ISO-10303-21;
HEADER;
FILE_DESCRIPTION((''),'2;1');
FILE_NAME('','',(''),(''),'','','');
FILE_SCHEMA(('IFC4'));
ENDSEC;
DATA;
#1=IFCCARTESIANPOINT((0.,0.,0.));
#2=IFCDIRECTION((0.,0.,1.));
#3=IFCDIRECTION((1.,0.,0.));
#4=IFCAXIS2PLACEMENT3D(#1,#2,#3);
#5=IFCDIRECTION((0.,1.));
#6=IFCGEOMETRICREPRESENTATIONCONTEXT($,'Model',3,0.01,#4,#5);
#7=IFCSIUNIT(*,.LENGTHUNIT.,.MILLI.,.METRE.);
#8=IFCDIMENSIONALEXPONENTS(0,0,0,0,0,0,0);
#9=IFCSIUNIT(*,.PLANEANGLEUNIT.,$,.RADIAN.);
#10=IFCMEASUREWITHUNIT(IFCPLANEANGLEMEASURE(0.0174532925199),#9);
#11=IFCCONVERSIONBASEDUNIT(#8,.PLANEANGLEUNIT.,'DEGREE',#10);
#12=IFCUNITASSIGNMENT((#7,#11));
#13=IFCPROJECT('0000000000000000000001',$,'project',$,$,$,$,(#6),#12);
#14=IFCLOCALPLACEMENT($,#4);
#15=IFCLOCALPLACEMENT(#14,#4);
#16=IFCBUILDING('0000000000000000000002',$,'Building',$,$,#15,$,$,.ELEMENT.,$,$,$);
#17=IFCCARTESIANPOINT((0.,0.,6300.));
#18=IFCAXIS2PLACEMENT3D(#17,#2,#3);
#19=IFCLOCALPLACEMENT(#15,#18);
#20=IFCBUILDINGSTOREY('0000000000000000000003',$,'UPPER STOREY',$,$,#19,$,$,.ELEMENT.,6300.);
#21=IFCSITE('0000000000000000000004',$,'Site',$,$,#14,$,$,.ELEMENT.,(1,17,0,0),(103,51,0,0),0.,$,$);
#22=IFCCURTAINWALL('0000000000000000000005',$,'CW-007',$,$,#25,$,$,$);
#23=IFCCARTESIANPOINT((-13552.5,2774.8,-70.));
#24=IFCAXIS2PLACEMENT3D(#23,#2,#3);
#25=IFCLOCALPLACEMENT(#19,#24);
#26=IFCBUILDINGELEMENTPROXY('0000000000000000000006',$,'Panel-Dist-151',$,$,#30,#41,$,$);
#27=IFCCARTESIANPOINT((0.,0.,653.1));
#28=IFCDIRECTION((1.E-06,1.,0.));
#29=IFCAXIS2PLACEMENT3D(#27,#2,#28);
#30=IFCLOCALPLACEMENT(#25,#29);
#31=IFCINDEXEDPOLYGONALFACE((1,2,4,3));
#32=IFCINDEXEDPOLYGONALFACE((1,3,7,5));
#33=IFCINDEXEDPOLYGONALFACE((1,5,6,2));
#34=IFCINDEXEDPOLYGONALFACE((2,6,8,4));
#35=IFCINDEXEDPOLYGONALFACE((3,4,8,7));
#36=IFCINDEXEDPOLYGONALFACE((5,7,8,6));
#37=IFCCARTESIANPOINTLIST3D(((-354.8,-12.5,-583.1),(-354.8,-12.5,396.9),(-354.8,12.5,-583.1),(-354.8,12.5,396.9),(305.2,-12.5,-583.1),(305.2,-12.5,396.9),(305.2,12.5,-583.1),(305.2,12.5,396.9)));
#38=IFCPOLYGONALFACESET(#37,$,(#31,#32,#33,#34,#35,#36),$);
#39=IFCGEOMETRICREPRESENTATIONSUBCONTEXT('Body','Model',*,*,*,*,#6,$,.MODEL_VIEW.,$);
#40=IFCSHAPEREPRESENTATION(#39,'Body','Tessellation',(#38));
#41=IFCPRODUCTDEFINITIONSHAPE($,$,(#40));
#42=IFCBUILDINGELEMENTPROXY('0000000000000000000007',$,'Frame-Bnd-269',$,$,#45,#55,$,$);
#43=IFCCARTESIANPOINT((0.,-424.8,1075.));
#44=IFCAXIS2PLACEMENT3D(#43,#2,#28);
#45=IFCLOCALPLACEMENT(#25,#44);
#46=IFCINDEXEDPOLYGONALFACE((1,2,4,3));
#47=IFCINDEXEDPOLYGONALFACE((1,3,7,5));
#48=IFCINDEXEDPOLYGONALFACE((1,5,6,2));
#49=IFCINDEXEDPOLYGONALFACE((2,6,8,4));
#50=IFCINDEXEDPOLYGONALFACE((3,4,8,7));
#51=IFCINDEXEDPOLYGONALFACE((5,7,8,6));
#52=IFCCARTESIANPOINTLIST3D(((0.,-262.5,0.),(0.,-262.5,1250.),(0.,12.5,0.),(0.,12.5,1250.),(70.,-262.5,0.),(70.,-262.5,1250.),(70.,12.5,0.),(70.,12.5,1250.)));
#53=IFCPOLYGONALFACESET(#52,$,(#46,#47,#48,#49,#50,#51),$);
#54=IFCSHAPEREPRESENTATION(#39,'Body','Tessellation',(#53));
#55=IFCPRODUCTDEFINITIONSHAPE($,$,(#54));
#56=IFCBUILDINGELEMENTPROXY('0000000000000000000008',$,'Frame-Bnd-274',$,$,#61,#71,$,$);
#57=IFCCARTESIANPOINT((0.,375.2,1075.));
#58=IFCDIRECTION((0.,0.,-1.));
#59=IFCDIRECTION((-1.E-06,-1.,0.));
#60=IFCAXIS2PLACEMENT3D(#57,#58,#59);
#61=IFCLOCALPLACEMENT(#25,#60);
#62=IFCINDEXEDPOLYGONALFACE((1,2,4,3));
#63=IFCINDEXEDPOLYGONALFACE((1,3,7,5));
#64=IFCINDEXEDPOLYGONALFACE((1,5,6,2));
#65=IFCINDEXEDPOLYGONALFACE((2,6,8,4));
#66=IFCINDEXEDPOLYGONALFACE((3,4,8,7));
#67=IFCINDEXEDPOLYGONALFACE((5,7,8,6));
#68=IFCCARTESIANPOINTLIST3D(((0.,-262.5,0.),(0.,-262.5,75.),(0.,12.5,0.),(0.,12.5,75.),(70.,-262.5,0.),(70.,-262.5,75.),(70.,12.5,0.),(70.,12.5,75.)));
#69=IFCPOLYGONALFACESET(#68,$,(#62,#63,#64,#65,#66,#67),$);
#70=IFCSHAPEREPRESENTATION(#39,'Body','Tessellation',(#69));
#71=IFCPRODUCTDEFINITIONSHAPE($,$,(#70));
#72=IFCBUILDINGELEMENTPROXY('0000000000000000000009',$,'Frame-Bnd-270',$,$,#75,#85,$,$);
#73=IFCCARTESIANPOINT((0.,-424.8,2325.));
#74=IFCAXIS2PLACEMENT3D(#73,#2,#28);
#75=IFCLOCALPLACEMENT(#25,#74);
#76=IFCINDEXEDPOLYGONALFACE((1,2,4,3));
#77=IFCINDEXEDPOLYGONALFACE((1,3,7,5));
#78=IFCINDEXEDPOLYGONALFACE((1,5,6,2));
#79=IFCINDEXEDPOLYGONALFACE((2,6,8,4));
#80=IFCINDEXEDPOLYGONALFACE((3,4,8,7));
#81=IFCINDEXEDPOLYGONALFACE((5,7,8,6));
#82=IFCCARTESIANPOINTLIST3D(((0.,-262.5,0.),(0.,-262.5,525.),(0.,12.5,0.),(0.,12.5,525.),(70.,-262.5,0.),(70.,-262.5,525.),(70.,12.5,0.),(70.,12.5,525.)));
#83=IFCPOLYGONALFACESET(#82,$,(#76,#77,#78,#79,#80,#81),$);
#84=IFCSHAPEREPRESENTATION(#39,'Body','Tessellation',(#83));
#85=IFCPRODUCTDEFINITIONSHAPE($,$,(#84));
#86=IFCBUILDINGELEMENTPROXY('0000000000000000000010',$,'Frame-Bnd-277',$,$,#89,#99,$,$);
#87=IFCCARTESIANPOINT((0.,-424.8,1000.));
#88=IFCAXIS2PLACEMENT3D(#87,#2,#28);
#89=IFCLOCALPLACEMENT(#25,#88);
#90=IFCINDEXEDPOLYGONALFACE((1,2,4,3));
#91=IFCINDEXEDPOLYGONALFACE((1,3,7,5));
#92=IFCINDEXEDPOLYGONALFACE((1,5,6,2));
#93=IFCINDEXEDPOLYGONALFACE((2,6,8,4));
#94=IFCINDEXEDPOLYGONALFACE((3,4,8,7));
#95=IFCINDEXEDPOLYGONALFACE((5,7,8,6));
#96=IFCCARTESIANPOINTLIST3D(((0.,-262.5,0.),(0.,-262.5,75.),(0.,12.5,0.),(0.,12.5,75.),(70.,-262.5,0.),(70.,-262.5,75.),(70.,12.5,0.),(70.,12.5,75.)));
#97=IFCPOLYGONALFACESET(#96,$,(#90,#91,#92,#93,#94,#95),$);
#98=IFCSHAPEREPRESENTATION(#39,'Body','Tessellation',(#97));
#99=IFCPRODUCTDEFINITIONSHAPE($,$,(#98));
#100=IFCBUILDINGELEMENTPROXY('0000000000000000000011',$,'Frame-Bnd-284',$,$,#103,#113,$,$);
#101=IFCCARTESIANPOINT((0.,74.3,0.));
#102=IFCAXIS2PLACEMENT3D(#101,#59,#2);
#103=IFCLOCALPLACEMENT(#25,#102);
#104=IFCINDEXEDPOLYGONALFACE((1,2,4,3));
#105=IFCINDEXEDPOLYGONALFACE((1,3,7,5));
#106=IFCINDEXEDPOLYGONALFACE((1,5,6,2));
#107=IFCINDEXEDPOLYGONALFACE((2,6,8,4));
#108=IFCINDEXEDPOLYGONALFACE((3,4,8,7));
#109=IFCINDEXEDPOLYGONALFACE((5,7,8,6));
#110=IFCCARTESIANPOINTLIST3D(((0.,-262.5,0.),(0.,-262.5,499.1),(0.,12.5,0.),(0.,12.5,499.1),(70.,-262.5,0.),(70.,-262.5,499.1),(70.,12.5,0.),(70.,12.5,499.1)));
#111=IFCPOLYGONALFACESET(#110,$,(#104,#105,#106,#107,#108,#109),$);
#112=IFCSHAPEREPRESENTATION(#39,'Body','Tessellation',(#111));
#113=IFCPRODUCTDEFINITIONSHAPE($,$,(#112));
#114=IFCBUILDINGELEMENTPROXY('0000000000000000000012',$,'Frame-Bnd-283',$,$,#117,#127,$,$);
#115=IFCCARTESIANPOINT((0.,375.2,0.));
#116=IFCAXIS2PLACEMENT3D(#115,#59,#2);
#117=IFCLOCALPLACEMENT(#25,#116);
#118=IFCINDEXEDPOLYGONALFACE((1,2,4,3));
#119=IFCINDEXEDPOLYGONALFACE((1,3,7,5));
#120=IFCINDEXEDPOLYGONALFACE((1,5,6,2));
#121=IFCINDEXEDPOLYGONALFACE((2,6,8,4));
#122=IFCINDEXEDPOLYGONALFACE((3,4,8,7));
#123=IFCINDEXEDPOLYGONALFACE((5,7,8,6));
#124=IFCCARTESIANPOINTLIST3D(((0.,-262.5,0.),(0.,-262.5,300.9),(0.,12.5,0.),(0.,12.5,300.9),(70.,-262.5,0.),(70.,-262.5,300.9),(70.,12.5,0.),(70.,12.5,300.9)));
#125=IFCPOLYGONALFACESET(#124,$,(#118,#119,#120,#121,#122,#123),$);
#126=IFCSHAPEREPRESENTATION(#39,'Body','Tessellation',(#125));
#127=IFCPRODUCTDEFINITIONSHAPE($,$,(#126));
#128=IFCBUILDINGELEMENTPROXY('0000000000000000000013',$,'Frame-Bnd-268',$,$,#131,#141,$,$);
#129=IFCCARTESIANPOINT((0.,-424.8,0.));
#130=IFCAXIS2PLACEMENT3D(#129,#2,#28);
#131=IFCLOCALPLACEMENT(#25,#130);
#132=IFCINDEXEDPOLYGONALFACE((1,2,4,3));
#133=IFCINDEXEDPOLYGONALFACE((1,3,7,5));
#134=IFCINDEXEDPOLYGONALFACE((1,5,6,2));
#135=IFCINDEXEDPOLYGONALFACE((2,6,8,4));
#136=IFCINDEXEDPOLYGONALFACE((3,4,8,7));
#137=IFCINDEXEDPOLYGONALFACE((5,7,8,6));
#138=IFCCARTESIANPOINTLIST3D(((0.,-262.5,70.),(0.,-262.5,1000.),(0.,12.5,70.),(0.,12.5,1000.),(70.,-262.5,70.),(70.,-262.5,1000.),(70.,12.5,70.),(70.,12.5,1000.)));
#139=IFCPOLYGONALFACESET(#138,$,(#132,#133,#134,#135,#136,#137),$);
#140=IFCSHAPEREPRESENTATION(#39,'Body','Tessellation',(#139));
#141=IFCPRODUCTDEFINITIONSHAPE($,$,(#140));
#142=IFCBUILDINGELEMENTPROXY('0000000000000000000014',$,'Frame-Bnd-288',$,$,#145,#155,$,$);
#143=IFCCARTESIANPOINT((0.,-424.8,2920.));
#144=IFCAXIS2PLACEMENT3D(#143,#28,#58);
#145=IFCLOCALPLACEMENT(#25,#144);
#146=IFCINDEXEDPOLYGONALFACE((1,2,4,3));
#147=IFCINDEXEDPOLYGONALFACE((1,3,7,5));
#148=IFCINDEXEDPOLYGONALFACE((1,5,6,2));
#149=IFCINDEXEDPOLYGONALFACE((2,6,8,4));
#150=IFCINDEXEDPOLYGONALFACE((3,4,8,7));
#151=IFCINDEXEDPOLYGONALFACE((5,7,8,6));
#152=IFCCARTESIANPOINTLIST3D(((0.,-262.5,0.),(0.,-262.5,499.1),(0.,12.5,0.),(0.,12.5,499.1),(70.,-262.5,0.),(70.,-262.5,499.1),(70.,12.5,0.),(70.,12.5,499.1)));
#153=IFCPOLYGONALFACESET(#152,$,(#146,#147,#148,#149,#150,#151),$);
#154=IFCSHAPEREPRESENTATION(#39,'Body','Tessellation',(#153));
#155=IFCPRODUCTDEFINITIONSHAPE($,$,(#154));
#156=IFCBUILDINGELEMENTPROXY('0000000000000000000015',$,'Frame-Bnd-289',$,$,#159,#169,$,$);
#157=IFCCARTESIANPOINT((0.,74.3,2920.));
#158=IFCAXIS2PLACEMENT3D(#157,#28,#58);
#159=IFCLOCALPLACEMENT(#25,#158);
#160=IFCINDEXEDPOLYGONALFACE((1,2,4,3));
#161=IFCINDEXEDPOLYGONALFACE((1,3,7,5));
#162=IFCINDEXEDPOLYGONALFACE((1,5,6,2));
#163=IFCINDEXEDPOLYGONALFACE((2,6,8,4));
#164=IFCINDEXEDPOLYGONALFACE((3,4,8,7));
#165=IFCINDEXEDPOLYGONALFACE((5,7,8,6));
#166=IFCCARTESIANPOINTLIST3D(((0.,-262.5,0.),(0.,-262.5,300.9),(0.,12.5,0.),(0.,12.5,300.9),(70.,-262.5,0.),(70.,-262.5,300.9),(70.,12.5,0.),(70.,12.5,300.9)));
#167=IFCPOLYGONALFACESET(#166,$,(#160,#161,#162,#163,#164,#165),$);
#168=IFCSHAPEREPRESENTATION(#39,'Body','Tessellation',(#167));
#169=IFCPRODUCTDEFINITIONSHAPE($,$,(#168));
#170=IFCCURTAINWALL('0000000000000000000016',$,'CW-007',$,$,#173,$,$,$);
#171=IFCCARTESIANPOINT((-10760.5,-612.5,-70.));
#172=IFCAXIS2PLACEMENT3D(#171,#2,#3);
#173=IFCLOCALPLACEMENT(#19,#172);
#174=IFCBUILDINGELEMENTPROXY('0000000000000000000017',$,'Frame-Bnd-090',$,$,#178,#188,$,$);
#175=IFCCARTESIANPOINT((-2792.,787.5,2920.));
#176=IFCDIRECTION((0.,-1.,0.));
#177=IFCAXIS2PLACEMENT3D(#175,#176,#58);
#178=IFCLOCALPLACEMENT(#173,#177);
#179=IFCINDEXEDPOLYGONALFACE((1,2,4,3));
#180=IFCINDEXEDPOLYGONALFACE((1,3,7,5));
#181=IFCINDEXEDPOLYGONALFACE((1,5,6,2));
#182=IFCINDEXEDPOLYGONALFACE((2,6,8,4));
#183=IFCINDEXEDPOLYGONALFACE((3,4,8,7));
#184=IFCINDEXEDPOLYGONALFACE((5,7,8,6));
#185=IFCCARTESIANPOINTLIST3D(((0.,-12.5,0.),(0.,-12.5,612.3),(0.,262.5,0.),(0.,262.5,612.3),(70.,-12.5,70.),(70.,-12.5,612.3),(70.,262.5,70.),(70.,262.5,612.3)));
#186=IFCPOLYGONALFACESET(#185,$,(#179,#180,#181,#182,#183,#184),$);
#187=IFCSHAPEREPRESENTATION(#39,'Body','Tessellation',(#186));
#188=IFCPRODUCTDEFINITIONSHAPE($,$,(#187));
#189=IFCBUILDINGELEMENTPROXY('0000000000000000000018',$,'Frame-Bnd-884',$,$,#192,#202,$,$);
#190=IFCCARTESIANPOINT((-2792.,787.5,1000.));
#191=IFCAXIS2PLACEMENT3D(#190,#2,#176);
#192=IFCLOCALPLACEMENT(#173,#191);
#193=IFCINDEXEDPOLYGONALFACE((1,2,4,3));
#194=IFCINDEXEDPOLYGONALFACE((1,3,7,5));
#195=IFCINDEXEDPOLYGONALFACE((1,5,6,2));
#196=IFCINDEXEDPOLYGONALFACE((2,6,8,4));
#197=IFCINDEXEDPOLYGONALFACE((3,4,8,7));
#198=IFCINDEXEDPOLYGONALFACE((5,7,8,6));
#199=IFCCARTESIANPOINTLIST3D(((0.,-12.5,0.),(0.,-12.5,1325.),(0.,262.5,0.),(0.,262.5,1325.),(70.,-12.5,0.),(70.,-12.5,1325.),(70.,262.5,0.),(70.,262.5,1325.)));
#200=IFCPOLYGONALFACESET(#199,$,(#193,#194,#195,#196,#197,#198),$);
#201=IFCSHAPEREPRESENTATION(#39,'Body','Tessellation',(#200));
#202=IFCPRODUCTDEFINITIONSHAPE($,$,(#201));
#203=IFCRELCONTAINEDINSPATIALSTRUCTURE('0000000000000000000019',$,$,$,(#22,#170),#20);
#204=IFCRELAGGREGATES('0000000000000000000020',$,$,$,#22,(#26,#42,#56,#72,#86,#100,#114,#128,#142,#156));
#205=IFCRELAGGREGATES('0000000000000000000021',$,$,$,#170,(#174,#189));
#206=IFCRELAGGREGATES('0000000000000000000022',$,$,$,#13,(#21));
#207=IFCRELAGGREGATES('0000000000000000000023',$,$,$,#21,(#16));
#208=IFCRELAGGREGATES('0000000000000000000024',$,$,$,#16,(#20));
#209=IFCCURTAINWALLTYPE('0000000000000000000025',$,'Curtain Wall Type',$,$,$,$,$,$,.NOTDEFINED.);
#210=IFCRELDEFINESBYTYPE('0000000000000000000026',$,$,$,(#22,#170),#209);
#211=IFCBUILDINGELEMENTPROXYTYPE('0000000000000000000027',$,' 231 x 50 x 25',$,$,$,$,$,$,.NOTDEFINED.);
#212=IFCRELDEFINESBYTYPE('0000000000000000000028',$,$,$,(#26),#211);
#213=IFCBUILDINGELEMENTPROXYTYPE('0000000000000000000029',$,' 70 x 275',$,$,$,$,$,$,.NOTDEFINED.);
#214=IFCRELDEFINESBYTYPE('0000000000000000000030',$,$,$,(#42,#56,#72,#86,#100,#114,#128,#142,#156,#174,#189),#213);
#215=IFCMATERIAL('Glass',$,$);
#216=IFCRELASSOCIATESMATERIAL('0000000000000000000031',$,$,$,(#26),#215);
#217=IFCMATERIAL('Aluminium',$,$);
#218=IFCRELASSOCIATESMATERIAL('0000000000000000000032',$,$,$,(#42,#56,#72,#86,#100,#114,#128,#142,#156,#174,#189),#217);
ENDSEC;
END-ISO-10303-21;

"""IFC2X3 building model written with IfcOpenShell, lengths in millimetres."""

from ifc_helpers import new_model, entity, si_unit, converted_unit, direction, frame, origin_with_axes, place, context, subcontext, project, spatial, polyline, outline, extrude, clip, halfspace, material, type_object, element, aggregate, save


model = new_model("IFC2X3")

# Units and contexts
model_context = context("Model", 3, precision=0.01, world=origin_with_axes(), true_north=direction((0.0, 1.0)))
body_context = subcontext(model_context, "Body", "Model", "MODEL_VIEW")
ifc_project = project(units=[si_unit("LENGTHUNIT", "METRE", prefix="MILLI"), converted_unit("PLANEANGLEUNIT", "DEGREE", entity("IfcPlaneAngleMeasure", 0.0174532925199), si_unit("PLANEANGLEUNIT", "RADIAN"), dimensions=[0, 0, 0, 0, 0, 0, 0])], contexts=[model_context])

# Site, building, storey
site_placement = place(None, origin_with_axes())
site = spatial("IfcSite", under=ifc_project, at=site_placement, Name="Site", CompositionType="ELEMENT", RefLatitude=(1, 17, 0, 0), RefLongitude=(103, 51, 0, 0), RefElevation=0.0)
building_placement = place(site_placement, origin_with_axes())
building = spatial("IfcBuilding", under=site, at=building_placement, Name="Building", CompositionType="ELEMENT")
storey_placement = place(building_placement, frame((0.0, 0.0, 6300.0), z_axis=(0.0, 0.0, 1.0), x_axis=(1.0, 0.0, 0.0)))
storey = spatial("IfcBuildingStorey", under=building, at=storey_placement, Name="UPPER STOREY", CompositionType="ELEMENT", Elevation=6300.0)

# Curtain walls, building element proxies
curtain_wall_type = type_object("IfcCurtainWallType", Name="Curtain Wall Type", PredefinedType="NOTDEFINED")
curtain_wall_1_placement = place(storey_placement, frame((-13552.5, 2774.8, -70.0), z_axis=(0.0, 0.0, 1.0), x_axis=(1.0, 0.0, 0.0)))
curtain_wall_1 = element("IfcCurtainWall", 1, at=curtain_wall_1_placement, inside=storey, type_object=curtain_wall_type, Name="CW-007")
ifc_material_1 = material(Name="Glass")
building_element_proxy_type_1 = type_object("IfcBuildingElementProxyType", Name=" 231 x 50 x 25", PredefinedType="NOTDEFINED")
proxy_1_placement = place(curtain_wall_1_placement, frame((0.0, 0.0, 653.1), z_axis=(0.0, 0.0, 1.0), x_axis=(0.000001, 1.0, 0.0)))
proxy_1 = element("IfcBuildingElementProxy", 2, at=proxy_1_placement, type_object=building_element_proxy_type_1, material=ifc_material_1, Name="Panel-Dist-151", context=body_context, shape_type="SweptSolid", body=[
    extrude(outline(polyline([(-354.8, -396.9), (305.2, -396.9), (305.2, 583.1), (-354.8, 583.1), (-354.8, -396.9)])), frame((0.0, -12.5, 0.0), z_axis=(0.0, 1.0, 0.0), x_axis=(1.0, 0.0, 0.0)), (0.0, 0.0, 1.0), 25.0),
])
ifc_material_2 = material(Name="Aluminium")
building_element_proxy_type_2 = type_object("IfcBuildingElementProxyType", Name=" 70 x 275", PredefinedType="NOTDEFINED")
proxy_2_placement = place(curtain_wall_1_placement, frame((0.0, -424.8, 1075.0), z_axis=(0.0, 0.0, 1.0), x_axis=(0.000001, 1.0, 0.0)))
proxy_2 = element("IfcBuildingElementProxy", 3, at=proxy_2_placement, type_object=building_element_proxy_type_2, material=ifc_material_2, Name="Frame-Bnd-269", context=body_context, shape_type="SweptSolid", body=[
    extrude(outline(polyline([(262.5, 70.0), (-12.5, 70.0), (-12.5, 0.0), (262.5, 0.0), (262.5, 70.0)])), frame((0.0, 0.0, 0.0), z_axis=(0.0, 0.0, 1.0), x_axis=(0.000001, -1.0, 0.0)), (0.0, 0.0, 1.0), 1250.0),
])
proxy_3_placement = place(curtain_wall_1_placement, frame((0.0, 375.2, 1075.0), z_axis=(0.0, 0.0, -1.0), x_axis=(-0.000001, -1.0, 0.0)))
proxy_3 = element("IfcBuildingElementProxy", 4, at=proxy_3_placement, type_object=building_element_proxy_type_2, material=ifc_material_2, Name="Frame-Bnd-274", context=body_context, shape_type="SweptSolid", body=[
    extrude(outline(polyline([(262.5, 70.0), (-12.5, 70.0), (-12.5, 0.0), (262.5, 0.0), (262.5, 70.0)])), frame((0.0, 0.0, 0.0), z_axis=(0.0, 0.0, 1.0), x_axis=(-0.000001, -1.0, 0.0)), (0.0, 0.0, 1.0), 75.0),
])
proxy_4_placement = place(curtain_wall_1_placement, frame((0.0, -424.8, 2325.0), z_axis=(0.0, 0.0, 1.0), x_axis=(0.000001, 1.0, 0.0)))
proxy_4 = element("IfcBuildingElementProxy", 5, at=proxy_4_placement, type_object=building_element_proxy_type_2, material=ifc_material_2, Name="Frame-Bnd-270", context=body_context, shape_type="SweptSolid", body=[
    extrude(outline(polyline([(262.5, 70.0), (-12.5, 70.0), (-12.5, 0.0), (262.5, 0.0), (262.5, 70.0)])), frame((0.0, 0.0, 0.0), z_axis=(0.0, 0.0, 1.0), x_axis=(0.000001, -1.0, 0.0)), (0.0, 0.0, 1.0), 525.0),
])
proxy_5_placement = place(curtain_wall_1_placement, frame((0.0, -424.8, 1000.0), z_axis=(0.0, 0.0, 1.0), x_axis=(0.000001, 1.0, 0.0)))
proxy_5 = element("IfcBuildingElementProxy", 6, at=proxy_5_placement, type_object=building_element_proxy_type_2, material=ifc_material_2, Name="Frame-Bnd-277", context=body_context, shape_type="SweptSolid", body=[
    extrude(outline(polyline([(262.5, 70.0), (-12.5, 70.0), (-12.5, 0.0), (262.5, 0.0), (262.5, 70.0)])), frame((0.0, 0.0, 0.0), z_axis=(0.0, 0.0, 1.0), x_axis=(0.000001, -1.0, 0.0)), (0.0, 0.0, 1.0), 75.0),
])
proxy_6_placement = place(curtain_wall_1_placement, frame((0.0, 74.3, 0.0), z_axis=(-0.000001, -1.0, 0.0), x_axis=(0.0, 0.0, 1.0)))
proxy_6 = element("IfcBuildingElementProxy", 7, at=proxy_6_placement, type_object=building_element_proxy_type_2, material=ifc_material_2, Name="Frame-Bnd-284", context=body_context, shape_type="SweptSolid", body=[
    extrude(outline(polyline([(-262.5, -70.0), (12.5, -70.0), (12.5, 0.0), (-262.5, 0.0), (-262.5, -70.0)])), frame((0.0, 0.0, 0.0), z_axis=(0.0, 0.0, 1.0), x_axis=(0.0, 1.0, 0.0)), (0.0, 0.0, 1.0), 499.1),
])
proxy_7_placement = place(curtain_wall_1_placement, frame((0.0, 375.2, 0.0), z_axis=(-0.000001, -1.0, 0.0), x_axis=(0.0, 0.0, 1.0)))
proxy_7 = element("IfcBuildingElementProxy", 8, at=proxy_7_placement, type_object=building_element_proxy_type_2, material=ifc_material_2, Name="Frame-Bnd-283", context=body_context, shape_type="SweptSolid", body=[
    extrude(outline(polyline([(-262.5, -70.0), (12.5, -70.0), (12.5, 0.0), (-262.5, 0.0), (-262.5, -70.0)])), frame((0.0, 0.0, 0.0), z_axis=(0.0, 0.0, 1.0), x_axis=(0.0, 1.0, 0.0)), (0.0, 0.0, 1.0), 300.9),
])
proxy_8_placement = place(curtain_wall_1_placement, frame((0.0, -424.8, 0.0), z_axis=(0.0, 0.0, 1.0), x_axis=(0.000001, 1.0, 0.0)))
proxy_8 = element("IfcBuildingElementProxy", 9, at=proxy_8_placement, type_object=building_element_proxy_type_2, material=ifc_material_2, Name="Frame-Bnd-268", context=body_context, shape_type="SweptSolid", body=[
    extrude(outline(polyline([(262.5, 70.0), (-12.5, 70.0), (-12.5, 0.0), (262.5, 0.0), (262.5, 70.0)])), frame((0.0, 0.0, 70.0), z_axis=(0.0, 0.0, 1.0), x_axis=(0.000001, -1.0, 0.0)), (0.0, 0.0, 1.0), 930.0),
])
proxy_9_placement = place(curtain_wall_1_placement, frame((0.0, -424.8, 2920.0), z_axis=(0.000001, 1.0, 0.0), x_axis=(0.0, 0.0, -1.0)))
proxy_9 = element("IfcBuildingElementProxy", 10, at=proxy_9_placement, type_object=building_element_proxy_type_2, material=ifc_material_2, Name="Frame-Bnd-288", context=body_context, shape_type="SweptSolid", body=[
    extrude(outline(polyline([(262.5, 70.0), (-12.5, 70.0), (-12.5, 0.0), (262.5, 0.0), (262.5, 70.0)])), frame((0.0, 0.0, 0.0), z_axis=(0.0, 0.0, 1.0), x_axis=(0.0, -1.0, 0.0)), (0.0, 0.0, 1.0), 499.1),
])
proxy_10_placement = place(curtain_wall_1_placement, frame((0.0, 74.3, 2920.0), z_axis=(0.000001, 1.0, 0.0), x_axis=(0.0, 0.0, -1.0)))
proxy_10 = element("IfcBuildingElementProxy", 11, at=proxy_10_placement, type_object=building_element_proxy_type_2, material=ifc_material_2, Name="Frame-Bnd-289", context=body_context, shape_type="SweptSolid", body=[
    extrude(outline(polyline([(262.5, 70.0), (-12.5, 70.0), (-12.5, 0.0), (262.5, 0.0), (262.5, 70.0)])), frame((0.0, 0.0, 0.0), z_axis=(0.0, 0.0, 1.0), x_axis=(0.0, -1.0, 0.0)), (0.0, 0.0, 1.0), 300.9),
])
curtain_wall_2_placement = place(storey_placement, frame((-10760.5, -612.5, -70.0), z_axis=(0.0, 0.0, 1.0), x_axis=(1.0, 0.0, 0.0)))
curtain_wall_2 = element("IfcCurtainWall", 12, at=curtain_wall_2_placement, inside=storey, type_object=curtain_wall_type, Name="CW-007")
proxy_11_placement = place(curtain_wall_2_placement, frame((-2792.0, 787.5, 2920.0), z_axis=(0.0, -1.0, 0.0), x_axis=(0.0, 0.0, -1.0)))
proxy_11 = element("IfcBuildingElementProxy", 13, at=proxy_11_placement, type_object=building_element_proxy_type_2, material=ifc_material_2, Name="Frame-Bnd-090", context=body_context, shape_type="Clipping", body=[
    clip(extrude(outline(polyline([(-262.5, 70.0), (-262.5, 0.0), (12.5, 0.0), (12.5, 70.0), (-262.5, 70.0)])), frame((0.0, 0.0, 0.0), z_axis=(0.0, 0.0, 1.0), x_axis=(0.0, -1.0, 0.0)), (0.0, 0.0, 1.0), 612.3), halfspace(frame((0.0, 0.0, 0.0), z_axis=(-0.707106, 0.0, 0.707108), x_axis=(0.0, -1.0, 0.0)), True)),
])
proxy_12_placement = place(curtain_wall_2_placement, frame((-2792.0, 787.5, 1000.0), z_axis=(0.0, 0.0, 1.0), x_axis=(0.0, -1.0, 0.0)))
proxy_12 = element("IfcBuildingElementProxy", 14, at=proxy_12_placement, type_object=building_element_proxy_type_2, material=ifc_material_2, Name="Frame-Bnd-884", context=body_context, shape_type="SweptSolid", body=[
    extrude(outline(polyline([(262.5, -70.0), (262.5, 0.0), (-12.5, 0.0), (-12.5, -70.0), (262.5, -70.0)])), frame((0.0, 0.0, 0.0), z_axis=(0.0, 0.0, 1.0), x_axis=(0.0, 1.0, 0.0)), (0.0, 0.0, 1.0), 1325.0),
])

aggregate(curtain_wall_1, [proxy_1, proxy_2, proxy_3, proxy_4, proxy_5, proxy_6, proxy_7, proxy_8, proxy_9, proxy_10])
aggregate(curtain_wall_2, [proxy_11, proxy_12])

save(model, "model.ifc")
